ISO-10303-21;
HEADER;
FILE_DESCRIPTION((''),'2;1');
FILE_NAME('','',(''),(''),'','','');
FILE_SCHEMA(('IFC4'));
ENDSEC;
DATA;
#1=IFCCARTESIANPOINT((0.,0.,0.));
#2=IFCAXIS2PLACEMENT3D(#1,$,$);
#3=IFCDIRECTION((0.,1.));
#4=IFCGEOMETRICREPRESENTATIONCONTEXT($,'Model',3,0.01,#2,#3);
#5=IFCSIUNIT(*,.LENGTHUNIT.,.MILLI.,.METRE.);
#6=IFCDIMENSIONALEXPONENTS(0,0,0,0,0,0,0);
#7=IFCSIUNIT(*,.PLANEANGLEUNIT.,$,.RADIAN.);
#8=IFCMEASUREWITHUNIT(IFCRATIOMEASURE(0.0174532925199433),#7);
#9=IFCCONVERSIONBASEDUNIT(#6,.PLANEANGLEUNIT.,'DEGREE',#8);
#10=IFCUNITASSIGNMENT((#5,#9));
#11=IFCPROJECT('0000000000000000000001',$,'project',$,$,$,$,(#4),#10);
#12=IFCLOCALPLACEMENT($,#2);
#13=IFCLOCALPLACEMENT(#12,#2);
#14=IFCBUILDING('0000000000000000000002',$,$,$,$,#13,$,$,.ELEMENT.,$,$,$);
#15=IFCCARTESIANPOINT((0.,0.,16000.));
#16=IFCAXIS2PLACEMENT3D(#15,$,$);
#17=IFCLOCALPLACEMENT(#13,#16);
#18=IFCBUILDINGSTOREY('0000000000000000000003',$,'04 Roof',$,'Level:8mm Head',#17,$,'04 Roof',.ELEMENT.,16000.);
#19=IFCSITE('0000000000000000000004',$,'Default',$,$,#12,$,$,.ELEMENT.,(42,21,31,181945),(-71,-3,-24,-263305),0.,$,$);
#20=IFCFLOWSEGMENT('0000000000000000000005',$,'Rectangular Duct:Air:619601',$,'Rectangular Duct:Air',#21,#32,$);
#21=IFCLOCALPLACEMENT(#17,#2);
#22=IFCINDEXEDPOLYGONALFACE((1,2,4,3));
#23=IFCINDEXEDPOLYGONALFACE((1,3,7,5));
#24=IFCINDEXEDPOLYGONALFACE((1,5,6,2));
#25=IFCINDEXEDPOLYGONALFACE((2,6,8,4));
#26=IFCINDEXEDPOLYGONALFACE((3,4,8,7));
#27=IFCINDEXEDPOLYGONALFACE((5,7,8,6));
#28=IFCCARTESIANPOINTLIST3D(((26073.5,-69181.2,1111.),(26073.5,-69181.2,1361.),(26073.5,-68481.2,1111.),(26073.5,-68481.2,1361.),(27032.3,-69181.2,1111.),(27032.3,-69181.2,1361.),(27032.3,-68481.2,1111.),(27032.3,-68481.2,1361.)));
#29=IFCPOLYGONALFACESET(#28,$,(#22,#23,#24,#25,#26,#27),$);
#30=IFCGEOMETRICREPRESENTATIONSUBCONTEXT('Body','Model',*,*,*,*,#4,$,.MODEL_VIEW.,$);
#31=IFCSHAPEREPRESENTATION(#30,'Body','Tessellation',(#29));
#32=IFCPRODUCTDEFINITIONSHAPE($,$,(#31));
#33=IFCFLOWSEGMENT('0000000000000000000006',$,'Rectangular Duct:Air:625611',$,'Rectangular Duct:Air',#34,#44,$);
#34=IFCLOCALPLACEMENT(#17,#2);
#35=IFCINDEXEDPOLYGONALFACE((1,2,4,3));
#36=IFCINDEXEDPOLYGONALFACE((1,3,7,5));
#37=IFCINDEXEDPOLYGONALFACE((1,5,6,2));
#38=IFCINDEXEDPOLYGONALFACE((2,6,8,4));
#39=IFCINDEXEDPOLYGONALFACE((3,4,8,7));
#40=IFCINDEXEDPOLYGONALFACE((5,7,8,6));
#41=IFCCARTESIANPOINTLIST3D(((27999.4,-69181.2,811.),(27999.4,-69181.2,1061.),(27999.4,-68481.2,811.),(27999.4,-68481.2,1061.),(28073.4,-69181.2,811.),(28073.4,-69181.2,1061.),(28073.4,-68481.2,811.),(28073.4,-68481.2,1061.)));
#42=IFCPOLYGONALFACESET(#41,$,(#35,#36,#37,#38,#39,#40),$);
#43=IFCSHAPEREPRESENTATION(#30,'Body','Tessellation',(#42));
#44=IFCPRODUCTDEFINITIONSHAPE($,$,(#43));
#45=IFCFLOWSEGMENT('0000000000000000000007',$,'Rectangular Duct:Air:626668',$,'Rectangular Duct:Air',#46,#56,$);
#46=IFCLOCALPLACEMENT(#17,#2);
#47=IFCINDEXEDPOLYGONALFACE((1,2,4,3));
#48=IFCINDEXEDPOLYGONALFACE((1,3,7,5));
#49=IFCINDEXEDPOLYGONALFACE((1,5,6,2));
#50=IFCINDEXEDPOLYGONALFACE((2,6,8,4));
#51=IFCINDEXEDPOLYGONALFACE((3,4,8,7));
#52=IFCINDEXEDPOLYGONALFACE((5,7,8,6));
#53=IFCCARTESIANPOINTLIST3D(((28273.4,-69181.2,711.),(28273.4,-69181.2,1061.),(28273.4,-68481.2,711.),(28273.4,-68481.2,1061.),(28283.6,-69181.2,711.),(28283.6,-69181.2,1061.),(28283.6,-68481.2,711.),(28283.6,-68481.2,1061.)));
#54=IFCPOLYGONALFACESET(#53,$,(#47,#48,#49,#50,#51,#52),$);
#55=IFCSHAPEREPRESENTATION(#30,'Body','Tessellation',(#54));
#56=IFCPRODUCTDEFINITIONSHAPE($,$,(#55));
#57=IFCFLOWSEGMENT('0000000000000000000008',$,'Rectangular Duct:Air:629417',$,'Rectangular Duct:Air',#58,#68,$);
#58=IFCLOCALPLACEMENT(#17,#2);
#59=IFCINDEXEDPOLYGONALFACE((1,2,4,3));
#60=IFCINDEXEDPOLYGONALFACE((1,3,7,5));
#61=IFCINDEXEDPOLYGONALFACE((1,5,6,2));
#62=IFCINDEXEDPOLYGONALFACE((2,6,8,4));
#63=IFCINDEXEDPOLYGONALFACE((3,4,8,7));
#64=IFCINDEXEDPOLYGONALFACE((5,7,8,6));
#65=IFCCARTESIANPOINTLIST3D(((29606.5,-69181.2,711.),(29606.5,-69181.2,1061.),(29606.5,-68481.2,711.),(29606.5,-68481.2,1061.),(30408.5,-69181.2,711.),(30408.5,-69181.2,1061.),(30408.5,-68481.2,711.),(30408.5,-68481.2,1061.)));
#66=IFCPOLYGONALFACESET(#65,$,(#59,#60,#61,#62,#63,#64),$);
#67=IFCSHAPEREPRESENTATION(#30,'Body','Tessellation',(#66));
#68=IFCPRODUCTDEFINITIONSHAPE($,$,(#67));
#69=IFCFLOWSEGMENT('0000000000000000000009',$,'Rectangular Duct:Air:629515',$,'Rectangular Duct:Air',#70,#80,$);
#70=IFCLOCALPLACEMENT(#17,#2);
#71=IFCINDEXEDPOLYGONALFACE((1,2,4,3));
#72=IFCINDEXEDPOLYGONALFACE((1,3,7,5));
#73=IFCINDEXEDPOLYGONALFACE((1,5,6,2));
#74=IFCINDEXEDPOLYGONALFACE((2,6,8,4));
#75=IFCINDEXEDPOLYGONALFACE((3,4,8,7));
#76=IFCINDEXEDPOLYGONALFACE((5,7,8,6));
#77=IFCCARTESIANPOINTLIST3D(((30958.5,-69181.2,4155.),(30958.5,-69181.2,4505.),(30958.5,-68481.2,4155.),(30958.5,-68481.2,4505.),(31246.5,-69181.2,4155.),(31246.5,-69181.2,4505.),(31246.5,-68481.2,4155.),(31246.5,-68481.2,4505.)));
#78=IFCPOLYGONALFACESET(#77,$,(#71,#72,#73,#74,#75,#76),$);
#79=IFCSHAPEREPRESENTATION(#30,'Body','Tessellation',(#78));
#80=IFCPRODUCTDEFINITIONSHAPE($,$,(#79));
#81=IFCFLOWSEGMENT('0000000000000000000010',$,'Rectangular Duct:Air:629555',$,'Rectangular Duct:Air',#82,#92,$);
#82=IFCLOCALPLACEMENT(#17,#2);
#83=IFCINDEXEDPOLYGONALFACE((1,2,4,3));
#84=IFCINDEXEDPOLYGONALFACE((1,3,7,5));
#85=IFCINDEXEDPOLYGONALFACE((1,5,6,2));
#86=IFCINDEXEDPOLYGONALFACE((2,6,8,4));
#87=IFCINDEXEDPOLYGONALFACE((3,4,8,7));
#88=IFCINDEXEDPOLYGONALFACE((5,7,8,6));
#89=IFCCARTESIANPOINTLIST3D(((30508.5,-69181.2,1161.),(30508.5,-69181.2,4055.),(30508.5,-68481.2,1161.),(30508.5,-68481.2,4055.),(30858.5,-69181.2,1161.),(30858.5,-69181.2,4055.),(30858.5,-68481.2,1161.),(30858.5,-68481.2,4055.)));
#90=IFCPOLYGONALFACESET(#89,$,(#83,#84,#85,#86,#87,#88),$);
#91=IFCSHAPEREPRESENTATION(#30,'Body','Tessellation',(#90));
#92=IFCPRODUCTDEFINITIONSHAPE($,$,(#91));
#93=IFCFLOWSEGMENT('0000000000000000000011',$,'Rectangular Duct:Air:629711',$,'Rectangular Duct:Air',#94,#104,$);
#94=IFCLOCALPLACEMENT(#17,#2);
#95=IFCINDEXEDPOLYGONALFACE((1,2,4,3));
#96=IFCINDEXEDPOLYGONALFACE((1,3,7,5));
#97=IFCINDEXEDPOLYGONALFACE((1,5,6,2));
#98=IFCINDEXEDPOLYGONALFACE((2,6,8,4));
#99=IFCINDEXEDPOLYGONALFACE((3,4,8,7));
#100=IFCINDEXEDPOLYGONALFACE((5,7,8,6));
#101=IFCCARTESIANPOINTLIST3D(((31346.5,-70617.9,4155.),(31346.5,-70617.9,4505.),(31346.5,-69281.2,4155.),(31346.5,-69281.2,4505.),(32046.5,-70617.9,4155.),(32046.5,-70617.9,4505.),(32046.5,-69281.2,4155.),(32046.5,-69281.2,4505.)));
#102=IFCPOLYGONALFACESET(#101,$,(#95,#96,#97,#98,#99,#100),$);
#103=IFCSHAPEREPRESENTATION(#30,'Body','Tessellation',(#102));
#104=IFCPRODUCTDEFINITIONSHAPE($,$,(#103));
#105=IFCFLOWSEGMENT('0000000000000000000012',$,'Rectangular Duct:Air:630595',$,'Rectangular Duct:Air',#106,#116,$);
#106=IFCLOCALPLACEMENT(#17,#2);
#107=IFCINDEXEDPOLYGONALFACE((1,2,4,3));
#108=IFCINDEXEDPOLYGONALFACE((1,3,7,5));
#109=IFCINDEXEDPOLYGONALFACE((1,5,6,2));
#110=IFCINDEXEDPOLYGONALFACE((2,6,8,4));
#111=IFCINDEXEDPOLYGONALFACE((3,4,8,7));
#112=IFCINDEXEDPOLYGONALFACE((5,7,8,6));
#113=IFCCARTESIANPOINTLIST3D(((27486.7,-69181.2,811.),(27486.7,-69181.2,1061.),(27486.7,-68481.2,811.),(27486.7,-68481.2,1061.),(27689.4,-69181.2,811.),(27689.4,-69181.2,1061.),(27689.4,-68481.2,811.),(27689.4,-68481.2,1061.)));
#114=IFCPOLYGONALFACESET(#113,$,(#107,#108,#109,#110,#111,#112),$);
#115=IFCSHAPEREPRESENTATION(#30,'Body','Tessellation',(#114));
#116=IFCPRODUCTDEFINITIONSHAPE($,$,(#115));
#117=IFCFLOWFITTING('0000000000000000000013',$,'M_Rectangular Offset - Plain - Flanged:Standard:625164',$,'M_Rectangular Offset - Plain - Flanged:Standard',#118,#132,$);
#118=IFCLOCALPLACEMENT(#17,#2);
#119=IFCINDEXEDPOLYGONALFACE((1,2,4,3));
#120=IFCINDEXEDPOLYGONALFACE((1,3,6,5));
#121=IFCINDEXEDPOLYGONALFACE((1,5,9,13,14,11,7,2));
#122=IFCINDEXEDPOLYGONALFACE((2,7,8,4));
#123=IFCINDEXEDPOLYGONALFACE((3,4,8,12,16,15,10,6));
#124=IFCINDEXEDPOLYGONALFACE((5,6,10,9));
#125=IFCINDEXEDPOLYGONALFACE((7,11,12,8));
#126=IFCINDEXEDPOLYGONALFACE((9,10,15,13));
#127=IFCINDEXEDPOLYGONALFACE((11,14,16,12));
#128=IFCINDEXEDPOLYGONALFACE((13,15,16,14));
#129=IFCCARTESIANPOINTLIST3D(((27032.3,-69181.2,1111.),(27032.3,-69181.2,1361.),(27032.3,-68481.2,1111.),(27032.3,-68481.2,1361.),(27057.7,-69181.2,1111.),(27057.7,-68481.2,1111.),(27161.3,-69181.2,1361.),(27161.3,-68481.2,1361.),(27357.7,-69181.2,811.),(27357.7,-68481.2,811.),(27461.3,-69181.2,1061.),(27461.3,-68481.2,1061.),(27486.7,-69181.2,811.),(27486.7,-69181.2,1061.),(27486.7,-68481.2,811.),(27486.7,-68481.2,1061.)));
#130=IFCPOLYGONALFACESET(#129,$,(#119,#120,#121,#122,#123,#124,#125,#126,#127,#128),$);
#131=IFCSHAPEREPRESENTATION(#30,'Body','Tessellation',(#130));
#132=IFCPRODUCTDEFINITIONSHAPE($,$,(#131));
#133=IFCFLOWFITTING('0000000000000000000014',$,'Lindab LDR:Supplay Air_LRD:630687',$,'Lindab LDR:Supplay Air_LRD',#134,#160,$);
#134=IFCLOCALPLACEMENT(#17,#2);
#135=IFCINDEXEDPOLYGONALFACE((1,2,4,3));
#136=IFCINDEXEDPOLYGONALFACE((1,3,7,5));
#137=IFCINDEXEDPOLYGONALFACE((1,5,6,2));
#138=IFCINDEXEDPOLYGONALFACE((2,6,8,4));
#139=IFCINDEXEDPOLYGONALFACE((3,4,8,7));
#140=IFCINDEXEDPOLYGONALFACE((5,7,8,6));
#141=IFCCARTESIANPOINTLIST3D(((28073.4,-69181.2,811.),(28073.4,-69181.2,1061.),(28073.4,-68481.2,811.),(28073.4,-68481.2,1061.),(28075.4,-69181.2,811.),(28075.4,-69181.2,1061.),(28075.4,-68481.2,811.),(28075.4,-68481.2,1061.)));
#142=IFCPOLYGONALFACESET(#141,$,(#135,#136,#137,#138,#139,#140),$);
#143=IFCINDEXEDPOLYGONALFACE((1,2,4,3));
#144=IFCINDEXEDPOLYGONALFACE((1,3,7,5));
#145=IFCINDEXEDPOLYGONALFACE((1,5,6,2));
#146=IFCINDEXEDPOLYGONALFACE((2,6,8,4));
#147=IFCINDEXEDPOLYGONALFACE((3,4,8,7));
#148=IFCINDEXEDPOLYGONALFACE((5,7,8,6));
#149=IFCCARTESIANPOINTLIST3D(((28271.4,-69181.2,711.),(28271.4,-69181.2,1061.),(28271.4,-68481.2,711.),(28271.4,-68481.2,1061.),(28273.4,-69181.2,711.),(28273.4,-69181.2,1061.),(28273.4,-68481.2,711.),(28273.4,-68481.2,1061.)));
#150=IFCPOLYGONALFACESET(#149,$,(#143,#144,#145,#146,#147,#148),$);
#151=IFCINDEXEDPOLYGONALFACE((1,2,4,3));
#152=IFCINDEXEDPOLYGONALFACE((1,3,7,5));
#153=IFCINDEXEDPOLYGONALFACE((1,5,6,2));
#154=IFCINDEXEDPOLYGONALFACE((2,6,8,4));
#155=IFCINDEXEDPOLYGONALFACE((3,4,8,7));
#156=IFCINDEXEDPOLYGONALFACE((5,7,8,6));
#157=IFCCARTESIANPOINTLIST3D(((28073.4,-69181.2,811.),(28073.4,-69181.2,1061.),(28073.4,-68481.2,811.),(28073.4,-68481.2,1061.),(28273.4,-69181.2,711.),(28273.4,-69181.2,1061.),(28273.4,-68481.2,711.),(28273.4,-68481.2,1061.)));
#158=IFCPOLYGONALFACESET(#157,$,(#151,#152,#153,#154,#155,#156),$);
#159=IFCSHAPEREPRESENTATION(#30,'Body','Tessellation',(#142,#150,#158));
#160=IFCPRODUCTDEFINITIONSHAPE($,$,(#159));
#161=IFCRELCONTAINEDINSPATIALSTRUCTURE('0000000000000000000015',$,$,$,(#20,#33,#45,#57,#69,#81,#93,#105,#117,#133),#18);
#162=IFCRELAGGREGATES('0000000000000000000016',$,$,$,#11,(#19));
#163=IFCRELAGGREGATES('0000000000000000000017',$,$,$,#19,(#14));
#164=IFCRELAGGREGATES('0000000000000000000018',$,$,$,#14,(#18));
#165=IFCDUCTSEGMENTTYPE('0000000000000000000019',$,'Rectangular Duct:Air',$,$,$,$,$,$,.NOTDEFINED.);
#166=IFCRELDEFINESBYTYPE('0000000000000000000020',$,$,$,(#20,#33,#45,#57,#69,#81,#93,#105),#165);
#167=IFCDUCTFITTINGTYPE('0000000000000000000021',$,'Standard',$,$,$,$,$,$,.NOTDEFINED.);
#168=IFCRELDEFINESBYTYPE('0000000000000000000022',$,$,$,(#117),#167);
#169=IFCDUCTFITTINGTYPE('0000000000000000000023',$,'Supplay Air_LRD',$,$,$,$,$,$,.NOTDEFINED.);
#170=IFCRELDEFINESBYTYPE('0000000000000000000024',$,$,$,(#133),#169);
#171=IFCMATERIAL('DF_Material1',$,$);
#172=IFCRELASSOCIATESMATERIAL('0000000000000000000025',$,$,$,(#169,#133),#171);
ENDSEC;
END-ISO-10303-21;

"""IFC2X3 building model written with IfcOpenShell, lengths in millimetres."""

from ifc_helpers import new_model, entity, si_unit, converted_unit, direction, frame, frame_2d, origin, origin_2d_with_axis, place, context, subcontext, project, spatial, polyline, rectangle, outline, extrude, source, transform, mapped, material, type_object, type_shapes, element, save


model = new_model("IFC2X3")

# Units and contexts
model_context = context("Model", 3, precision=0.01, world=origin(), true_north=direction((0.0, 1.0)))
body_context = subcontext(model_context, "Body", "Model", "MODEL_VIEW")
ifc_project = project(units=[si_unit("LENGTHUNIT", "METRE", prefix="MILLI"), converted_unit("PLANEANGLEUNIT", "DEGREE", entity("IfcRatioMeasure", 0.0174532925199433), si_unit("PLANEANGLEUNIT", "RADIAN"), dimensions=[0, 0, 0, 0, 0, 0, 0])], contexts=[model_context])

# Site, building, storey
site_placement = place(None, origin())
site = spatial("IfcSite", under=ifc_project, at=site_placement, Name="Default", CompositionType="ELEMENT", RefLatitude=(42, 21, 31, 181945), RefLongitude=(-71, -3, -24, -263305), RefElevation=0.0)
building_placement = place(site_placement, origin())
building = spatial("IfcBuilding", under=site, at=building_placement, CompositionType="ELEMENT")
storey_placement = place(building_placement, frame((0.0, 0.0, 16000.0)))
storey = spatial("IfcBuildingStorey", under=building, at=storey_placement, Name="04 Roof", ObjectType="Level:8mm Head", LongName="04 Roof", CompositionType="ELEMENT", Elevation=16000.0)

# Flow segments
duct_segment_type = type_object("IfcDuctSegmentType", Name="Rectangular Duct:Air", PredefinedType="NOTDEFINED")
flow_segment_1_placement = place(storey_placement, frame((26073.5, -69181.2, 1111.0)))
element("IfcFlowSegment", 1, at=flow_segment_1_placement, inside=storey, type_object=duct_segment_type, Name="Rectangular Duct:Air:619601", ObjectType="Rectangular Duct:Air", context=body_context, shape_type="SweptSolid", body=[
    extrude(rectangle(XDim=958.8, YDim=700.0, at=frame_2d((0.0, 0.0), x_axis=(1.0, 0.0))), frame((479.4, 350.0, 0.0)), (0.0, 0.0, 1.0), 250.0),
])
flow_segment_2_placement = place(storey_placement, frame((27999.4, -69181.2, 811.0)))
element("IfcFlowSegment", 2, at=flow_segment_2_placement, inside=storey, type_object=duct_segment_type, Name="Rectangular Duct:Air:625611", ObjectType="Rectangular Duct:Air", context=body_context, shape_type="SweptSolid", body=[
    extrude(rectangle(XDim=74.0, YDim=700.0, at=origin_2d_with_axis()), frame((37.0, 350.0, 0.0), z_axis=(0.0, 0.0, 1.0), x_axis=(-1.0, 0.0, 0.0)), (0.0, 0.0, 1.0), 250.0),
])
flow_segment_3_placement = place(storey_placement, frame((28273.4, -69181.2, 711.0)))
element("IfcFlowSegment", 3, at=flow_segment_3_placement, inside=storey, type_object=duct_segment_type, Name="Rectangular Duct:Air:626668", ObjectType="Rectangular Duct:Air", context=body_context, shape_type="SweptSolid", body=[
    extrude(rectangle(XDim=10.2, YDim=700.0, at=frame_2d((0.0, 0.0), x_axis=(1.0, 0.0))), frame((5.1, 350.0, 0.0), z_axis=(0.0, 0.0, 1.0), x_axis=(-1.0, 0.0, 0.0)), (0.0, 0.0, 1.0), 350.0),
])
flow_segment_4_placement = place(storey_placement, frame((29606.5, -69181.2, 711.0)))
element("IfcFlowSegment", 4, at=flow_segment_4_placement, inside=storey, type_object=duct_segment_type, Name="Rectangular Duct:Air:629417", ObjectType="Rectangular Duct:Air", context=body_context, shape_type="SweptSolid", body=[
    extrude(rectangle(XDim=802.0, YDim=700.0, at=frame_2d((0.0, 0.0), x_axis=(1.0, 0.0))), frame((401.0, 350.0, 0.0)), (0.0, 0.0, 1.0), 350.0),
])
flow_segment_5_placement = place(storey_placement, frame((30958.5, -69181.2, 4155.0)))
element("IfcFlowSegment", 5, at=flow_segment_5_placement, inside=storey, type_object=duct_segment_type, Name="Rectangular Duct:Air:629515", ObjectType="Rectangular Duct:Air", context=body_context, shape_type="SweptSolid", body=[
    extrude(rectangle(XDim=288.0, YDim=700.0, at=frame_2d((0.0, 0.0), x_axis=(1.0, 0.0))), frame((144.0, 350.0, 0.0), z_axis=(0.0, 0.0, 1.0), x_axis=(-1.0, 0.0, 0.0)), (0.0, 0.0, 1.0), 350.0),
])
flow_segment_6_placement = place(storey_placement, frame((30508.5, -69181.2, 1161.0)))
element("IfcFlowSegment", 6, at=flow_segment_6_placement, inside=storey, type_object=duct_segment_type, Name="Rectangular Duct:Air:629555", ObjectType="Rectangular Duct:Air", context=body_context, shape_type="SweptSolid", body=[
    extrude(rectangle(XDim=350.0, YDim=700.0, at=origin_2d_with_axis()), frame((175.0, 350.0, 0.0), z_axis=(0.0, 0.0, 1.0), x_axis=(-1.0, 0.0, 0.0)), (0.0, 0.0, 1.0), 2894.0),
])
flow_segment_7_placement = place(storey_placement, frame((31346.5, -70617.9, 4155.0)))
element("IfcFlowSegment", 7, at=flow_segment_7_placement, inside=storey, type_object=duct_segment_type, Name="Rectangular Duct:Air:629711", ObjectType="Rectangular Duct:Air", context=body_context, shape_type="SweptSolid", body=[
    extrude(rectangle(XDim=1336.7, YDim=700.0, at=frame_2d((0.0, 0.0), x_axis=(1.0, 0.0))), frame((350.0, 668.4, 0.0), z_axis=(0.0, 0.0, 1.0), x_axis=(0.0, 1.0, 0.0)), (0.0, 0.0, 1.0), 350.0),
])
flow_segment_8_placement = place(storey_placement, frame((27486.7, -69181.2, 811.0)))
element("IfcFlowSegment", 8, at=flow_segment_8_placement, inside=storey, type_object=duct_segment_type, Name="Rectangular Duct:Air:630595", ObjectType="Rectangular Duct:Air", context=body_context, shape_type="SweptSolid", body=[
    extrude(rectangle(XDim=202.8, YDim=700.0, at=frame_2d((0.0, 0.0), x_axis=(1.0, 0.0))), frame((101.4, 350.0, 0.0)), (0.0, 0.0, 1.0), 250.0),
])

# Flow fittings
duct_fitting_type_1 = type_object("IfcDuctFittingType", Name="Standard", PredefinedType="NOTDEFINED")
shared_shape_1 = source(origin(), body_context, "Body", "SweptSolid", [
    extrude(outline(polyline([(-227.2, -275.0), (-98.2, -275.0), (201.8, 25.0), (227.2, 25.0), (227.2, 275.0), (98.2, 275.0), (-201.8, -25.0), (-227.2, -25.0), (-227.2, -275.0)])), frame((227.2, 150.0, -350.0)), (0.0, 0.0, 1.0), 700.0),
])
type_shapes(duct_fitting_type_1, [shared_shape_1])
flow_fitting_1_placement = place(storey_placement, frame((27032.3, -68831.2, 1236.0), z_axis=(0.0, 1.0, 0.0), x_axis=(1.0, 0.0, 0.0)))
element("IfcFlowFitting", 9, at=flow_fitting_1_placement, inside=storey, type_object=duct_fitting_type_1, Name="M_Rectangular Offset - Plain - Flanged:Standard:625164", ObjectType="M_Rectangular Offset - Plain - Flanged:Standard", context=body_context, shape_type="MappedRepresentation", body=[
    mapped(shared_shape_1, transform((0.0, 0.0, 0.0), scale=1.0)),
])
ifc_material = material(Name="DF_Material1")
duct_fitting_type_2 = type_object("IfcDuctFittingType", Name="Supplay Air_LRD", PredefinedType="NOTDEFINED", material=ifc_material)
shared_shape_2 = source(origin(), body_context, "Body", "SweptSolid", [
    extrude(rectangle(XDim=2.0, YDim=700.0, at=origin_2d_with_axis()), frame((199.0, 0.0, -75.0), z_axis=(0.0, 0.0, 1.0), x_axis=(-1.0, 0.0, 0.0)), (0.0, 0.0, 1.0), 250.0),
    extrude(rectangle(XDim=2.0, YDim=700.0, at=origin_2d_with_axis()), frame((1.0, 0.0, -175.0), z_axis=(0.0, 0.0, 1.0), x_axis=(-1.0, 0.0, 0.0)), (0.0, 0.0, 1.0), 350.0),
    extrude(outline(polyline([(-100.0, -150.0), (100.0, -150.0), (100.0, 100.0), (-100.0, 200.0), (-100.0, -150.0)])), frame((100.0, -350.0, 25.0), z_axis=(0.0, 1.0, 0.0), x_axis=(1.0, 0.0, 0.0)), (0.0, 0.0, 1.0), 700.0),
])
type_shapes(duct_fitting_type_2, [shared_shape_2])
flow_fitting_2_placement = place(storey_placement, frame((28273.4, -68831.2, 886.0), z_axis=(0.0, 0.0, 1.0), x_axis=(-1.0, 0.0, 0.0)))
element("IfcFlowFitting", 10, at=flow_fitting_2_placement, inside=storey, type_object=duct_fitting_type_2, material=ifc_material, Name="Lindab LDR:Supplay Air_LRD:630687", ObjectType="Lindab LDR:Supplay Air_LRD", context=body_context, shape_type="MappedRepresentation", body=[
    mapped(shared_shape_2, transform((0.0, 0.0, 0.0), scale=1.0)),
])

save(model, "model.ifc")
